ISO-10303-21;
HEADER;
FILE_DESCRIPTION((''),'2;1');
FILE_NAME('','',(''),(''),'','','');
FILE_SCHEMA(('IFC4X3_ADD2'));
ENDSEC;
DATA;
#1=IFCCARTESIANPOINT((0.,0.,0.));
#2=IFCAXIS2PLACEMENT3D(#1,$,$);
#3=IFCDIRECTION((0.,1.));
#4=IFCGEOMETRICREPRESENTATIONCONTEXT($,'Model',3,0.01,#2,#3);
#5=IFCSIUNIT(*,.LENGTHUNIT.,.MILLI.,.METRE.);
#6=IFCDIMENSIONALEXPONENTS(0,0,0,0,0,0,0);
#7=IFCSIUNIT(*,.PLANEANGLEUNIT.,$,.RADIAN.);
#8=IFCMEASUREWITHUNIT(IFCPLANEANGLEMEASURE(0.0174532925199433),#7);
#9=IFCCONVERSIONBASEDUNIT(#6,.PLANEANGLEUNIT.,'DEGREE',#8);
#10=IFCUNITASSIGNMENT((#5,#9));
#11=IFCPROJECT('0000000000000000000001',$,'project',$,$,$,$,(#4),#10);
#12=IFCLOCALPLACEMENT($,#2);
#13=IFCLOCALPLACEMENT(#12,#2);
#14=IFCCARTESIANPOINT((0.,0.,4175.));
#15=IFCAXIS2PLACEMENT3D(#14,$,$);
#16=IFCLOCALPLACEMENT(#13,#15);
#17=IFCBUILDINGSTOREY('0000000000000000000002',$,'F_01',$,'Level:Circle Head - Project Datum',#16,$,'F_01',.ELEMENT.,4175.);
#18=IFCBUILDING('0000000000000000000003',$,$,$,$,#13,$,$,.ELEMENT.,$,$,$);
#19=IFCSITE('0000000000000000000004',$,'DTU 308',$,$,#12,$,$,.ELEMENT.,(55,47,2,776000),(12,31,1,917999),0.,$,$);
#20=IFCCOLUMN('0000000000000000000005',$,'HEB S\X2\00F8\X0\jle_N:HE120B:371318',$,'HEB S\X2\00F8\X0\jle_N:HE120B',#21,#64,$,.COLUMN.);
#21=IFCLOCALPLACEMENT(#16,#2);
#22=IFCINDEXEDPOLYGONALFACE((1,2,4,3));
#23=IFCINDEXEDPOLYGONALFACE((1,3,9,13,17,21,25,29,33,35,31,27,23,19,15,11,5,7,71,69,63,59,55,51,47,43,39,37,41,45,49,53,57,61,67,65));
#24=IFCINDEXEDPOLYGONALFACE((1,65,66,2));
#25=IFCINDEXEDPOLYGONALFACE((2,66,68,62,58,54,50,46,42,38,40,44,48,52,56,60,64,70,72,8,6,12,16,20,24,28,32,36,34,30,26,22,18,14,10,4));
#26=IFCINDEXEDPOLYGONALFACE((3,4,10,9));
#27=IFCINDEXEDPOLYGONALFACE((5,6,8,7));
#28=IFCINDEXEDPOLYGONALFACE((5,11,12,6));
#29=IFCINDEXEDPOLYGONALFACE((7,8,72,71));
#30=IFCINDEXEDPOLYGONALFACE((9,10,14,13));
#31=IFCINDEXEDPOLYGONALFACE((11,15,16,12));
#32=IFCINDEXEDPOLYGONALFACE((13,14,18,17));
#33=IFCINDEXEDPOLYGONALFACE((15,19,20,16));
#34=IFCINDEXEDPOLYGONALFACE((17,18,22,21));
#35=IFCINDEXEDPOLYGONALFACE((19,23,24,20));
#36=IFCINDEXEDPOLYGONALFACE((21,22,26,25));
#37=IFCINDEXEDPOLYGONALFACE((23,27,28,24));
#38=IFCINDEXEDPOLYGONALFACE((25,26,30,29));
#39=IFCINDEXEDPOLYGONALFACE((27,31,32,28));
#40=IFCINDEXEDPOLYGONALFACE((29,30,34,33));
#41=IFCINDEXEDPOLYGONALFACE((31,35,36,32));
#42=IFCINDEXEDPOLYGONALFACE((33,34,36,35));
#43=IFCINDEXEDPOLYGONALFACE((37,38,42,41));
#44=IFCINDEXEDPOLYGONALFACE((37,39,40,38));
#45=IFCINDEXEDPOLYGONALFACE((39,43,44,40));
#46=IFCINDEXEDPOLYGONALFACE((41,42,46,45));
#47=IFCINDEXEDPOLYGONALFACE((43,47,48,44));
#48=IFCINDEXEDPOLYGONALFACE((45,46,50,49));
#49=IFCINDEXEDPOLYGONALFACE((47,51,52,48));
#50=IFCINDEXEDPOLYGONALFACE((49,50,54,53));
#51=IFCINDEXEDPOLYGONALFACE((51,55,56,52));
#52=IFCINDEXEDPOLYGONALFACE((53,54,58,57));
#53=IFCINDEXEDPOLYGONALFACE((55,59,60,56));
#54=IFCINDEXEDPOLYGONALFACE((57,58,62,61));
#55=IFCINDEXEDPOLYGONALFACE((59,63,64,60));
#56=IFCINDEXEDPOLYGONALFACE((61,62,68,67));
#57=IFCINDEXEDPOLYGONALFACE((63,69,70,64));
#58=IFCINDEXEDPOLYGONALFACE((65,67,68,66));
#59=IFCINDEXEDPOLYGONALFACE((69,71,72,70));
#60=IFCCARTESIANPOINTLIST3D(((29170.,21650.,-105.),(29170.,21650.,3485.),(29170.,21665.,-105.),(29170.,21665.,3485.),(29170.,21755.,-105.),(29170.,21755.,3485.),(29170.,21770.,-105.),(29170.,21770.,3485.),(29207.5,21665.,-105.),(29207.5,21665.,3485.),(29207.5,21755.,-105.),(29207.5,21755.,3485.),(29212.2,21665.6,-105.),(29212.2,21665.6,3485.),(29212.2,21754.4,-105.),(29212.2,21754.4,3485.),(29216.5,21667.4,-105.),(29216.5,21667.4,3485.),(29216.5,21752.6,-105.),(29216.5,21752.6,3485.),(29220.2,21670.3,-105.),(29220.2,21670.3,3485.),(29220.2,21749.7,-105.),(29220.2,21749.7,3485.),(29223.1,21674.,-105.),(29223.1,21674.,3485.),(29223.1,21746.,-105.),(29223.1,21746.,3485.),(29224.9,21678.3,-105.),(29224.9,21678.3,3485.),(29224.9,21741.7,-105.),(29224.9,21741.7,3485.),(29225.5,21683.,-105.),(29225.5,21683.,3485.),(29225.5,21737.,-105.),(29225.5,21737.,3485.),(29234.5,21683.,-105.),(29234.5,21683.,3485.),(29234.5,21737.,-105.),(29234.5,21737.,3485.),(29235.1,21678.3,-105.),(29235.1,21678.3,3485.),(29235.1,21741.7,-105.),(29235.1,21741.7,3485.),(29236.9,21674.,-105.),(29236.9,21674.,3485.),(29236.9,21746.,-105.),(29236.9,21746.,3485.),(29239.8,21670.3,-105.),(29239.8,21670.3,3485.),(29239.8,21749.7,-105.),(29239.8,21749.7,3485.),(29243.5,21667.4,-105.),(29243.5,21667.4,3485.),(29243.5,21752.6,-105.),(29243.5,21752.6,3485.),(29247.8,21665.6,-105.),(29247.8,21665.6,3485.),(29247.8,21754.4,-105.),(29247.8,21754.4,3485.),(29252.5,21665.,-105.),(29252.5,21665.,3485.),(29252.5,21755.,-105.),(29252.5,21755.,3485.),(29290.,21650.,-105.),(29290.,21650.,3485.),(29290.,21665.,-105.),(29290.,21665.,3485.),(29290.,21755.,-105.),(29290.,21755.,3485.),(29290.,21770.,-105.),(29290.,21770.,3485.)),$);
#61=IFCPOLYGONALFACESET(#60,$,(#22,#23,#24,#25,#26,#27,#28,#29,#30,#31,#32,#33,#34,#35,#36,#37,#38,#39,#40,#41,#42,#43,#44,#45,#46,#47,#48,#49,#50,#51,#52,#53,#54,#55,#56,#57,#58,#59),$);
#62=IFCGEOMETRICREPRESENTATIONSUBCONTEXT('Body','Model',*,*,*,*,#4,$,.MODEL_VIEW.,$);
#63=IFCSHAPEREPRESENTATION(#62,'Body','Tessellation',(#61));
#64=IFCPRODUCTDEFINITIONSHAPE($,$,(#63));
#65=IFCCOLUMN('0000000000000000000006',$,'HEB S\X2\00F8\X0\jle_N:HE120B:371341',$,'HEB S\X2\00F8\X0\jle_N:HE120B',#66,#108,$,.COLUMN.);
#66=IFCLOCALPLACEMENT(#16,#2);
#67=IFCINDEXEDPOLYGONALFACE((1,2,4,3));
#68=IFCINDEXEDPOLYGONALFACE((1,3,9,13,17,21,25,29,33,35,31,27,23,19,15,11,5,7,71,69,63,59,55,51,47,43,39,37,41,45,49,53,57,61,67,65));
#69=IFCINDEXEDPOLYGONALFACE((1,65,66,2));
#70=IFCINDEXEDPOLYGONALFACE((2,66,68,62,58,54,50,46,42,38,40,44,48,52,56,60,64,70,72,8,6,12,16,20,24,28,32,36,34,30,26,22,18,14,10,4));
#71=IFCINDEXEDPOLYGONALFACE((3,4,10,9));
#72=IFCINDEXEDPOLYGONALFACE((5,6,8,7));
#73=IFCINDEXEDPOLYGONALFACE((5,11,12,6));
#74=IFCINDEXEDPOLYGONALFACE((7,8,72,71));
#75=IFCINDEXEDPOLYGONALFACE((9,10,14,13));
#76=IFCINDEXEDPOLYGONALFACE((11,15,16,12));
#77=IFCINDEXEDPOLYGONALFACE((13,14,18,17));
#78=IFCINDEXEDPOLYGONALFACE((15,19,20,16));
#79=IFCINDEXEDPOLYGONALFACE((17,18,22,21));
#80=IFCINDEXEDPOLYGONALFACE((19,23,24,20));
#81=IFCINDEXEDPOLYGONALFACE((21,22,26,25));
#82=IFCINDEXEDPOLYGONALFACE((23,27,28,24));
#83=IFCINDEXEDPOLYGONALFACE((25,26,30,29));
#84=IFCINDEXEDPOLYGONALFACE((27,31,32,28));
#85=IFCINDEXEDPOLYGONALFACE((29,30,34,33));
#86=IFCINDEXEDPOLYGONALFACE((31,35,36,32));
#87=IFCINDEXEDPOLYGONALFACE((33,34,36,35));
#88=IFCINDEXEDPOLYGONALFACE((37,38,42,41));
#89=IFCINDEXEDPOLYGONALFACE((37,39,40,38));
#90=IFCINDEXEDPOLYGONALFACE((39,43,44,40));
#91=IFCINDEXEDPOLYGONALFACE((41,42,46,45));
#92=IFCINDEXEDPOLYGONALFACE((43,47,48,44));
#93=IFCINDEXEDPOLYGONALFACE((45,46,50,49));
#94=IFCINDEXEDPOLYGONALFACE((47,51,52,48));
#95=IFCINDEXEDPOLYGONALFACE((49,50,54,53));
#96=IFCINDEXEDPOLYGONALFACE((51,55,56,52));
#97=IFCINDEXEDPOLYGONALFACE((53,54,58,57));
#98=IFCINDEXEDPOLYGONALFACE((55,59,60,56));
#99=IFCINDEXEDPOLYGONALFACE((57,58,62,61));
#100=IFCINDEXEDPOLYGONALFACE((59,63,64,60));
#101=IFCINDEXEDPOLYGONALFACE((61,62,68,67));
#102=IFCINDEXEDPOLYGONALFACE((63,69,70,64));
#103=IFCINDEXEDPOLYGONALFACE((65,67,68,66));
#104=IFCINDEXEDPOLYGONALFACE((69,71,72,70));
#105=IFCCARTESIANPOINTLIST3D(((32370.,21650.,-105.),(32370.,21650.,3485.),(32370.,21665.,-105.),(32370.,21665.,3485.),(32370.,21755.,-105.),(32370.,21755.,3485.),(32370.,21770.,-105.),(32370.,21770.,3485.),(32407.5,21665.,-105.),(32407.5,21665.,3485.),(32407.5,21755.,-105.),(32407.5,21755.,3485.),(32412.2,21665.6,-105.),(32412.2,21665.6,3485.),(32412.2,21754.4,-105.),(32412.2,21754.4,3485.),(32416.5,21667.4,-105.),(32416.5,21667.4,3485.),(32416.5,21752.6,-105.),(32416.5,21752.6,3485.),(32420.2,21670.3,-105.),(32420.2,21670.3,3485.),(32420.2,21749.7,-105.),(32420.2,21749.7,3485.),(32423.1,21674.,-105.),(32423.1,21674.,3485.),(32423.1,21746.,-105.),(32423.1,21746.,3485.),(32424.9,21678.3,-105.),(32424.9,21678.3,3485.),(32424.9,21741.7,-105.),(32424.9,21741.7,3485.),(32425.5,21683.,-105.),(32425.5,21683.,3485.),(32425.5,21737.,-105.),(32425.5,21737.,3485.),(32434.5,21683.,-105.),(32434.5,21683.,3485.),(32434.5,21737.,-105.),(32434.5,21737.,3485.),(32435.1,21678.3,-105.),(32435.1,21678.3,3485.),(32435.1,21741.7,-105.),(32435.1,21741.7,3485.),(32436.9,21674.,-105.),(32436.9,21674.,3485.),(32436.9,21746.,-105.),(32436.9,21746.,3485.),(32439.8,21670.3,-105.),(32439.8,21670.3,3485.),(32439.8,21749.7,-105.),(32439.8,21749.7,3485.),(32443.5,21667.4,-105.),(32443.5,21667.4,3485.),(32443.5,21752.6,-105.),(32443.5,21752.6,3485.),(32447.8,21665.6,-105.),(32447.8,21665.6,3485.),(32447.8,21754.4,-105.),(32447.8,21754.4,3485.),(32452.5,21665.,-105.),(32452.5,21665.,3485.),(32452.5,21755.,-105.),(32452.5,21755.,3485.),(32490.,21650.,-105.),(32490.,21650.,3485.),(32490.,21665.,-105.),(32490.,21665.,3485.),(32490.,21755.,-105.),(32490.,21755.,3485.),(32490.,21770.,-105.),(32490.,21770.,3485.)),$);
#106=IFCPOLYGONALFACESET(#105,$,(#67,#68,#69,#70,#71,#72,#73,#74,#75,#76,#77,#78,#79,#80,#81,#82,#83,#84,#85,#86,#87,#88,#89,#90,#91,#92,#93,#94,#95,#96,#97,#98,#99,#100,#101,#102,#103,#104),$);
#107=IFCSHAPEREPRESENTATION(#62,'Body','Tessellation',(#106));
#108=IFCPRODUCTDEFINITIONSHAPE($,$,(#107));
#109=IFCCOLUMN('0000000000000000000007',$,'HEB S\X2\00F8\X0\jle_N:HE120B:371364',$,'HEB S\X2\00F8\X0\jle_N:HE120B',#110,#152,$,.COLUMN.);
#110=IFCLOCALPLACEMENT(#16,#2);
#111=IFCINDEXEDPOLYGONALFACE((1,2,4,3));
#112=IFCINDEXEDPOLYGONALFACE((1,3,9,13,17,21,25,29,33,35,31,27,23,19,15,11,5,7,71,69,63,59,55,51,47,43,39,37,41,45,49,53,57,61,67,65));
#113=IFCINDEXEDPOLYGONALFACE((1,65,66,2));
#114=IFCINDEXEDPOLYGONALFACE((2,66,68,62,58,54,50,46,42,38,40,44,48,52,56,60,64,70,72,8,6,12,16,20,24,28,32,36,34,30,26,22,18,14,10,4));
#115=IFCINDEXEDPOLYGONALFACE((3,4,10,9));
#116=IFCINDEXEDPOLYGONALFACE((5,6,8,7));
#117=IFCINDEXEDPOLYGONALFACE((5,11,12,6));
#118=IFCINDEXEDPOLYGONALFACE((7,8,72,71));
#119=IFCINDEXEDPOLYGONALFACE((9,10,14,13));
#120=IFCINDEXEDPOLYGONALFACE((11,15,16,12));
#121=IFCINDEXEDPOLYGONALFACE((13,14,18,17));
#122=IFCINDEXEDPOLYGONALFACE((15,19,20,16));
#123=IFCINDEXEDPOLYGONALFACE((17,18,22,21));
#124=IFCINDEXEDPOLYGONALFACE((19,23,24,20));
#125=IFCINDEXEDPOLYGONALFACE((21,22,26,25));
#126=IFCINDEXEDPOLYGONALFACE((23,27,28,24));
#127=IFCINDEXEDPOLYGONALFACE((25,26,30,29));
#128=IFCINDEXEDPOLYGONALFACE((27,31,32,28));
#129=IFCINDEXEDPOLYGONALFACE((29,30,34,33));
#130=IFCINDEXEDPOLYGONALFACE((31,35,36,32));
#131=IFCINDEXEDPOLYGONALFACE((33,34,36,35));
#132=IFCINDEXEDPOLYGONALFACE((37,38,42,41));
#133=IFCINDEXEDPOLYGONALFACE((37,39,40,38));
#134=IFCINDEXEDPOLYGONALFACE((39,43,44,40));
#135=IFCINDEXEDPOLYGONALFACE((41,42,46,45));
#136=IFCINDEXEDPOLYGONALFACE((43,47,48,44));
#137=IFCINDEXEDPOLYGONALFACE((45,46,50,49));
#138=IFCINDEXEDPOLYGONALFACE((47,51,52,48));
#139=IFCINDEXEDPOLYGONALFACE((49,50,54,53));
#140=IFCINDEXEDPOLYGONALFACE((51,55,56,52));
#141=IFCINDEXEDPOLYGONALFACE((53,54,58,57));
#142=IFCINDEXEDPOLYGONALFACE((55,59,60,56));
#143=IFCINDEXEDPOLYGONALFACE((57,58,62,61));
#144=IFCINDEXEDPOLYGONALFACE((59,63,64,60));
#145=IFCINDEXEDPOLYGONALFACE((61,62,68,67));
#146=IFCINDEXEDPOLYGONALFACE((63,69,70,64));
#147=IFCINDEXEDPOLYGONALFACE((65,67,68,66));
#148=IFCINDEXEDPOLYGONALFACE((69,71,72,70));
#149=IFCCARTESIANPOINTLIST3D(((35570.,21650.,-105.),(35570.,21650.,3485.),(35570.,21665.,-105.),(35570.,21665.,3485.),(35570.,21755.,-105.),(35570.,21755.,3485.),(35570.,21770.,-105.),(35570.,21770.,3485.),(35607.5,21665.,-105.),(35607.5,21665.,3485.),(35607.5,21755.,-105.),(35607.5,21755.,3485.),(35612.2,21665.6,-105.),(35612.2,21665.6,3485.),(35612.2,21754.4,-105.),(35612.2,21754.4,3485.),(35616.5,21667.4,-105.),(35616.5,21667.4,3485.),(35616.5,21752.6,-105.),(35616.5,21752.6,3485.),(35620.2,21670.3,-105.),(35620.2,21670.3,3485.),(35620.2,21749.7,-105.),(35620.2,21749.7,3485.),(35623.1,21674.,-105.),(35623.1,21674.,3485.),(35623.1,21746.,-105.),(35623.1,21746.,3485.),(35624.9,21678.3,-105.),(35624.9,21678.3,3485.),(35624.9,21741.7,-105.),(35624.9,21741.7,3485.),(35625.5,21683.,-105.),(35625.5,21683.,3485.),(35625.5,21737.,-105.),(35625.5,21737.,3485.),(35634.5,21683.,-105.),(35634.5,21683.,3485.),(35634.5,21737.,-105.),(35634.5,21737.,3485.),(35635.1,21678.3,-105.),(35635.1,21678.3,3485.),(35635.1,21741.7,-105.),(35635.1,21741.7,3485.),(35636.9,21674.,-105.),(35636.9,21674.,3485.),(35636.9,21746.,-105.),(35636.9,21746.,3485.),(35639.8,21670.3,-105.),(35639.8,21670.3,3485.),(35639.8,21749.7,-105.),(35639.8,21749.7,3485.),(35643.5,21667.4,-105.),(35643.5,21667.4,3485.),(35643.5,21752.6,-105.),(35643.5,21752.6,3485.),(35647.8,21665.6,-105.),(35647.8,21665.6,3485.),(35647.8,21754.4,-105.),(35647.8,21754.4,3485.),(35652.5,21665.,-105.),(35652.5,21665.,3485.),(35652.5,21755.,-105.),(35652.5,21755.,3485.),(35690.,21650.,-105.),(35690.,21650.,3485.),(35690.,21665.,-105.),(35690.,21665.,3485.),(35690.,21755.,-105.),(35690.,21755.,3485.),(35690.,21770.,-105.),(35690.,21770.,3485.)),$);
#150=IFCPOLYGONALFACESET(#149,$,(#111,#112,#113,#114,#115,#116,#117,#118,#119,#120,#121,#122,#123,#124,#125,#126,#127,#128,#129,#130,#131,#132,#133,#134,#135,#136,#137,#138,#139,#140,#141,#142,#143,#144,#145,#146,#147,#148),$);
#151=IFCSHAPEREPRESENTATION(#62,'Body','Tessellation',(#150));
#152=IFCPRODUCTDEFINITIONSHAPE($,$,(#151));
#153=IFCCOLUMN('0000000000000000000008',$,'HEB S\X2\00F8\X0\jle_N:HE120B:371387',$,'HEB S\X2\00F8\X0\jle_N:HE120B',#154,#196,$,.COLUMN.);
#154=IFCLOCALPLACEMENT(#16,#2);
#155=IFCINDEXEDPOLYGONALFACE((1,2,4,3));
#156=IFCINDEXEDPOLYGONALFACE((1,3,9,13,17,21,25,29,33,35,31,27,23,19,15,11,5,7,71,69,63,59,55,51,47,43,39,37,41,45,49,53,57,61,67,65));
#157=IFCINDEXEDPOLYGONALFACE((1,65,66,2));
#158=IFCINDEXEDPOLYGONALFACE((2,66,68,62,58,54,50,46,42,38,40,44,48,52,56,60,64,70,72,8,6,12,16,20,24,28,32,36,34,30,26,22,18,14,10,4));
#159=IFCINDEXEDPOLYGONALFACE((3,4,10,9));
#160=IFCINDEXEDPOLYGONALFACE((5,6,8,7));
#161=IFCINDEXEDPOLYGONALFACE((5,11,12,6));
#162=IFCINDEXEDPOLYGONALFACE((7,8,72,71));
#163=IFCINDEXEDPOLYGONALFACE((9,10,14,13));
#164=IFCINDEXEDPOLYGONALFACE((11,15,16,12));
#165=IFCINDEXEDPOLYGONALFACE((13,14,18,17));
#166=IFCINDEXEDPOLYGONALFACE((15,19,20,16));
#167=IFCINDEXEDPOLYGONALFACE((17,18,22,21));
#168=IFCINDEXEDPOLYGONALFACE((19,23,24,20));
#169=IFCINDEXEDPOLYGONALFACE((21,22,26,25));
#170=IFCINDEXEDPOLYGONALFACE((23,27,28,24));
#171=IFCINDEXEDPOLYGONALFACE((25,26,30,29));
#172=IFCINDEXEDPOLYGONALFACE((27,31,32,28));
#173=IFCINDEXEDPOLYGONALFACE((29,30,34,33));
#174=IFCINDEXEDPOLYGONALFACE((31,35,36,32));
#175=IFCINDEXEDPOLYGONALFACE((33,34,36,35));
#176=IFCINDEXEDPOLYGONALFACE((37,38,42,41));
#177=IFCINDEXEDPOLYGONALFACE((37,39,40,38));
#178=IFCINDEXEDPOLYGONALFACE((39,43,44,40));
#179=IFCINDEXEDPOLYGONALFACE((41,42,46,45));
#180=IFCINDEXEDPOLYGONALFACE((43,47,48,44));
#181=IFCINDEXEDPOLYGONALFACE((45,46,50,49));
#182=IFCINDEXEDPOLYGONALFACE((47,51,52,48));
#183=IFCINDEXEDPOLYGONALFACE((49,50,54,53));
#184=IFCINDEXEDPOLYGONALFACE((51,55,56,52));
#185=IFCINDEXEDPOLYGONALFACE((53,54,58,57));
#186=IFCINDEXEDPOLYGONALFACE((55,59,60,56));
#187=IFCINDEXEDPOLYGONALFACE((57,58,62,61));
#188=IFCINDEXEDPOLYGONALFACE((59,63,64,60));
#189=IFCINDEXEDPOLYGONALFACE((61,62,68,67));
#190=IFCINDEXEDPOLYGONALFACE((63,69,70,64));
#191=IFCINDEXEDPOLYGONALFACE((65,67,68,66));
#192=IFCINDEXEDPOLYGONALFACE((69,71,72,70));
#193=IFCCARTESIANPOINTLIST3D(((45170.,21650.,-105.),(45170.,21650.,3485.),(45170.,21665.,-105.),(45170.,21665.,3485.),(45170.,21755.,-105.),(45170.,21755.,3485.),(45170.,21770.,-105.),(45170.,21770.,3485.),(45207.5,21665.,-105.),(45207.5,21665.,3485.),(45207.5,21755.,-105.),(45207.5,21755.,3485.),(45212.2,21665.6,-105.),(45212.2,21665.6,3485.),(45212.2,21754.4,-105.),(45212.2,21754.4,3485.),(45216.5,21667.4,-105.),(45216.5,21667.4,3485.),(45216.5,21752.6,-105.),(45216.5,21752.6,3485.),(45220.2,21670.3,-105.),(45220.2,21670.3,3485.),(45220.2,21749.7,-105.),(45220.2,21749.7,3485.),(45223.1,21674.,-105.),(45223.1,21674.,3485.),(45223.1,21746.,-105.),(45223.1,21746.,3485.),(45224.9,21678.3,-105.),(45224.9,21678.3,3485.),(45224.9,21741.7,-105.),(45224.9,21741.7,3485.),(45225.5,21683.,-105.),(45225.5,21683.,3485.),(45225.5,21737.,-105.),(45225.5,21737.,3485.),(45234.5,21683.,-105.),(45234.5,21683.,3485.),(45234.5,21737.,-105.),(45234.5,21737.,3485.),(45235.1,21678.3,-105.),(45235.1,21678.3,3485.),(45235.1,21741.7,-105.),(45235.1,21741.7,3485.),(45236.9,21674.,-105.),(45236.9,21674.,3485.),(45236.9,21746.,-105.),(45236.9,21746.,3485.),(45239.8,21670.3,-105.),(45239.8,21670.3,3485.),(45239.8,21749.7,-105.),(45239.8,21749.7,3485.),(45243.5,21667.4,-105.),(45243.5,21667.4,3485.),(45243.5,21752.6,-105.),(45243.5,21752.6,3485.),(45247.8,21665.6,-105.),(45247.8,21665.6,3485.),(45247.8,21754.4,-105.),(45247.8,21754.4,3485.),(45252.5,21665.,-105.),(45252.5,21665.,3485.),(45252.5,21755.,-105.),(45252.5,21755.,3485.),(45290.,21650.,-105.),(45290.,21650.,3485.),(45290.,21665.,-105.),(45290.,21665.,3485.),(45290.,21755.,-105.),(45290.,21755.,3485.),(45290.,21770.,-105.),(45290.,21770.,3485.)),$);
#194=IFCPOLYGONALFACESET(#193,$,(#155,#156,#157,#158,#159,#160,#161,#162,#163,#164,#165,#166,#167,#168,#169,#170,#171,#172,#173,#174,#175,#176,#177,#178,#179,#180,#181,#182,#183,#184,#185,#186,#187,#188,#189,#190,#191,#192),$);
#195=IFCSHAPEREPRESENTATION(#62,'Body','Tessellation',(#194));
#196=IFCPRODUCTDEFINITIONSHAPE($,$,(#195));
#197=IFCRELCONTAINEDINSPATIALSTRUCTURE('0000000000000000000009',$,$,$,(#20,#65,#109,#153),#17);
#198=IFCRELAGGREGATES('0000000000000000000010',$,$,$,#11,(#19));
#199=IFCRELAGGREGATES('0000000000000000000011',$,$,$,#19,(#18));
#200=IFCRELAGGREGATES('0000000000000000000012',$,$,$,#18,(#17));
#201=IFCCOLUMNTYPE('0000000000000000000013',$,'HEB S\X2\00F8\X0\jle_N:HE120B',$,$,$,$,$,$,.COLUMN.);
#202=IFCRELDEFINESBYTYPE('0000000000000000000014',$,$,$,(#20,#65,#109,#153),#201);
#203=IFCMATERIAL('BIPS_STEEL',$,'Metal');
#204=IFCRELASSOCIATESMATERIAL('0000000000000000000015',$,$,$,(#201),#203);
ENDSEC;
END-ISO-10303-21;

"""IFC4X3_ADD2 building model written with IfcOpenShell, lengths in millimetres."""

from ifc_helpers import new_model, entity, si_unit, converted_unit, direction, frame, frame_2d, origin, place, context, subcontext, project, spatial, i_section, extrude, source, transform, mapped, material, material_profile, profile_set, type_object, type_shapes, element, save


model = new_model("IFC4X3_ADD2")

# Units and contexts
model_context = context("Model", 3, precision=0.01, world=origin(), true_north=direction((0.0, 1.0)))
body_context = subcontext(model_context, "Body", "Model", "MODEL_VIEW")
ifc_project = project(units=[si_unit("LENGTHUNIT", "METRE", prefix="MILLI"), converted_unit("PLANEANGLEUNIT", "DEGREE", entity("IfcPlaneAngleMeasure", 0.0174532925199433), si_unit("PLANEANGLEUNIT", "RADIAN"), dimensions=[0, 0, 0, 0, 0, 0, 0])], contexts=[model_context])

# Site, building, storey
site_placement = place(None, origin())
site = spatial("IfcSite", under=ifc_project, at=site_placement, Name="DTU 308", CompositionType="ELEMENT", RefLatitude=(55, 47, 2, 776000), RefLongitude=(12, 31, 1, 917999), RefElevation=0.0)
building_placement = place(site_placement, origin())
building = spatial("IfcBuilding", under=site, at=building_placement, CompositionType="ELEMENT")
storey_placement = place(building_placement, frame((0.0, 0.0, 4175.0)))
storey = spatial("IfcBuildingStorey", under=building, at=storey_placement, Name="F_01", ObjectType="Level:Circle Head - Project Datum", LongName="F_01", CompositionType="ELEMENT", Elevation=4175.0)

# Columns
ifc_material_1 = material(Name="BIPS_STEEL", Category="Metal")
ifc_material_profile_1 = material_profile(ifc_material_1, i_section(OverallWidth=120.0, OverallDepth=120.0, WebThickness=9.0, FlangeThickness=15.0, FilletRadius=18.0, at=frame_2d((0.0, 0.0), x_axis=(1.0, 0.0))), Name="HE120B")
ifc_profile_set_1 = profile_set([ifc_material_profile_1], Name="HE120B")
column_type_1 = type_object("IfcColumnType", Name="HEB Søjle_N:HE120B", PredefinedType="COLUMN", material=ifc_profile_set_1)
shared_shape_1 = source(origin(), body_context, "Body", "SweptSolid", [
    extrude(i_section(OverallWidth=120.0, OverallDepth=120.0, WebThickness=9.0, FlangeThickness=15.0, FilletRadius=18.0, at=frame_2d((0.0, 0.0), x_axis=(1.0, 0.0))), frame((0.0, 0.0, 4070.0), z_axis=(0.0, 0.0, 1.0), x_axis=(-1.0, 0.0, 0.0)), (0.0, 0.0, 1.0), 3590.0),
])
type_shapes(column_type_1, [shared_shape_1])
for number, where, name in (
    (1, (29230.0, 21710.0, -4175.0), "HEB Søjle_N:HE120B:371318"),
    (2, (32430.0, 21710.0, -4175.0), "HEB Søjle_N:HE120B:371341"),
    (3, (35630.0, 21710.0, -4175.0), "HEB Søjle_N:HE120B:371364"),
    (4, (45230.0, 21710.0, -4175.0), "HEB Søjle_N:HE120B:371387"),
):
    element("IfcColumn", number, at=place(storey_placement, frame(where)), inside=storey, type_object=column_type_1, Name=name, ObjectType="HEB Søjle_N:HE120B", PredefinedType="COLUMN", context=body_context, shape_type="MappedRepresentation", body=[
        mapped(shared_shape_1, transform((0.0, 0.0, 0.0), scale=1.0)),
    ])

save(model, "model.ifc")
